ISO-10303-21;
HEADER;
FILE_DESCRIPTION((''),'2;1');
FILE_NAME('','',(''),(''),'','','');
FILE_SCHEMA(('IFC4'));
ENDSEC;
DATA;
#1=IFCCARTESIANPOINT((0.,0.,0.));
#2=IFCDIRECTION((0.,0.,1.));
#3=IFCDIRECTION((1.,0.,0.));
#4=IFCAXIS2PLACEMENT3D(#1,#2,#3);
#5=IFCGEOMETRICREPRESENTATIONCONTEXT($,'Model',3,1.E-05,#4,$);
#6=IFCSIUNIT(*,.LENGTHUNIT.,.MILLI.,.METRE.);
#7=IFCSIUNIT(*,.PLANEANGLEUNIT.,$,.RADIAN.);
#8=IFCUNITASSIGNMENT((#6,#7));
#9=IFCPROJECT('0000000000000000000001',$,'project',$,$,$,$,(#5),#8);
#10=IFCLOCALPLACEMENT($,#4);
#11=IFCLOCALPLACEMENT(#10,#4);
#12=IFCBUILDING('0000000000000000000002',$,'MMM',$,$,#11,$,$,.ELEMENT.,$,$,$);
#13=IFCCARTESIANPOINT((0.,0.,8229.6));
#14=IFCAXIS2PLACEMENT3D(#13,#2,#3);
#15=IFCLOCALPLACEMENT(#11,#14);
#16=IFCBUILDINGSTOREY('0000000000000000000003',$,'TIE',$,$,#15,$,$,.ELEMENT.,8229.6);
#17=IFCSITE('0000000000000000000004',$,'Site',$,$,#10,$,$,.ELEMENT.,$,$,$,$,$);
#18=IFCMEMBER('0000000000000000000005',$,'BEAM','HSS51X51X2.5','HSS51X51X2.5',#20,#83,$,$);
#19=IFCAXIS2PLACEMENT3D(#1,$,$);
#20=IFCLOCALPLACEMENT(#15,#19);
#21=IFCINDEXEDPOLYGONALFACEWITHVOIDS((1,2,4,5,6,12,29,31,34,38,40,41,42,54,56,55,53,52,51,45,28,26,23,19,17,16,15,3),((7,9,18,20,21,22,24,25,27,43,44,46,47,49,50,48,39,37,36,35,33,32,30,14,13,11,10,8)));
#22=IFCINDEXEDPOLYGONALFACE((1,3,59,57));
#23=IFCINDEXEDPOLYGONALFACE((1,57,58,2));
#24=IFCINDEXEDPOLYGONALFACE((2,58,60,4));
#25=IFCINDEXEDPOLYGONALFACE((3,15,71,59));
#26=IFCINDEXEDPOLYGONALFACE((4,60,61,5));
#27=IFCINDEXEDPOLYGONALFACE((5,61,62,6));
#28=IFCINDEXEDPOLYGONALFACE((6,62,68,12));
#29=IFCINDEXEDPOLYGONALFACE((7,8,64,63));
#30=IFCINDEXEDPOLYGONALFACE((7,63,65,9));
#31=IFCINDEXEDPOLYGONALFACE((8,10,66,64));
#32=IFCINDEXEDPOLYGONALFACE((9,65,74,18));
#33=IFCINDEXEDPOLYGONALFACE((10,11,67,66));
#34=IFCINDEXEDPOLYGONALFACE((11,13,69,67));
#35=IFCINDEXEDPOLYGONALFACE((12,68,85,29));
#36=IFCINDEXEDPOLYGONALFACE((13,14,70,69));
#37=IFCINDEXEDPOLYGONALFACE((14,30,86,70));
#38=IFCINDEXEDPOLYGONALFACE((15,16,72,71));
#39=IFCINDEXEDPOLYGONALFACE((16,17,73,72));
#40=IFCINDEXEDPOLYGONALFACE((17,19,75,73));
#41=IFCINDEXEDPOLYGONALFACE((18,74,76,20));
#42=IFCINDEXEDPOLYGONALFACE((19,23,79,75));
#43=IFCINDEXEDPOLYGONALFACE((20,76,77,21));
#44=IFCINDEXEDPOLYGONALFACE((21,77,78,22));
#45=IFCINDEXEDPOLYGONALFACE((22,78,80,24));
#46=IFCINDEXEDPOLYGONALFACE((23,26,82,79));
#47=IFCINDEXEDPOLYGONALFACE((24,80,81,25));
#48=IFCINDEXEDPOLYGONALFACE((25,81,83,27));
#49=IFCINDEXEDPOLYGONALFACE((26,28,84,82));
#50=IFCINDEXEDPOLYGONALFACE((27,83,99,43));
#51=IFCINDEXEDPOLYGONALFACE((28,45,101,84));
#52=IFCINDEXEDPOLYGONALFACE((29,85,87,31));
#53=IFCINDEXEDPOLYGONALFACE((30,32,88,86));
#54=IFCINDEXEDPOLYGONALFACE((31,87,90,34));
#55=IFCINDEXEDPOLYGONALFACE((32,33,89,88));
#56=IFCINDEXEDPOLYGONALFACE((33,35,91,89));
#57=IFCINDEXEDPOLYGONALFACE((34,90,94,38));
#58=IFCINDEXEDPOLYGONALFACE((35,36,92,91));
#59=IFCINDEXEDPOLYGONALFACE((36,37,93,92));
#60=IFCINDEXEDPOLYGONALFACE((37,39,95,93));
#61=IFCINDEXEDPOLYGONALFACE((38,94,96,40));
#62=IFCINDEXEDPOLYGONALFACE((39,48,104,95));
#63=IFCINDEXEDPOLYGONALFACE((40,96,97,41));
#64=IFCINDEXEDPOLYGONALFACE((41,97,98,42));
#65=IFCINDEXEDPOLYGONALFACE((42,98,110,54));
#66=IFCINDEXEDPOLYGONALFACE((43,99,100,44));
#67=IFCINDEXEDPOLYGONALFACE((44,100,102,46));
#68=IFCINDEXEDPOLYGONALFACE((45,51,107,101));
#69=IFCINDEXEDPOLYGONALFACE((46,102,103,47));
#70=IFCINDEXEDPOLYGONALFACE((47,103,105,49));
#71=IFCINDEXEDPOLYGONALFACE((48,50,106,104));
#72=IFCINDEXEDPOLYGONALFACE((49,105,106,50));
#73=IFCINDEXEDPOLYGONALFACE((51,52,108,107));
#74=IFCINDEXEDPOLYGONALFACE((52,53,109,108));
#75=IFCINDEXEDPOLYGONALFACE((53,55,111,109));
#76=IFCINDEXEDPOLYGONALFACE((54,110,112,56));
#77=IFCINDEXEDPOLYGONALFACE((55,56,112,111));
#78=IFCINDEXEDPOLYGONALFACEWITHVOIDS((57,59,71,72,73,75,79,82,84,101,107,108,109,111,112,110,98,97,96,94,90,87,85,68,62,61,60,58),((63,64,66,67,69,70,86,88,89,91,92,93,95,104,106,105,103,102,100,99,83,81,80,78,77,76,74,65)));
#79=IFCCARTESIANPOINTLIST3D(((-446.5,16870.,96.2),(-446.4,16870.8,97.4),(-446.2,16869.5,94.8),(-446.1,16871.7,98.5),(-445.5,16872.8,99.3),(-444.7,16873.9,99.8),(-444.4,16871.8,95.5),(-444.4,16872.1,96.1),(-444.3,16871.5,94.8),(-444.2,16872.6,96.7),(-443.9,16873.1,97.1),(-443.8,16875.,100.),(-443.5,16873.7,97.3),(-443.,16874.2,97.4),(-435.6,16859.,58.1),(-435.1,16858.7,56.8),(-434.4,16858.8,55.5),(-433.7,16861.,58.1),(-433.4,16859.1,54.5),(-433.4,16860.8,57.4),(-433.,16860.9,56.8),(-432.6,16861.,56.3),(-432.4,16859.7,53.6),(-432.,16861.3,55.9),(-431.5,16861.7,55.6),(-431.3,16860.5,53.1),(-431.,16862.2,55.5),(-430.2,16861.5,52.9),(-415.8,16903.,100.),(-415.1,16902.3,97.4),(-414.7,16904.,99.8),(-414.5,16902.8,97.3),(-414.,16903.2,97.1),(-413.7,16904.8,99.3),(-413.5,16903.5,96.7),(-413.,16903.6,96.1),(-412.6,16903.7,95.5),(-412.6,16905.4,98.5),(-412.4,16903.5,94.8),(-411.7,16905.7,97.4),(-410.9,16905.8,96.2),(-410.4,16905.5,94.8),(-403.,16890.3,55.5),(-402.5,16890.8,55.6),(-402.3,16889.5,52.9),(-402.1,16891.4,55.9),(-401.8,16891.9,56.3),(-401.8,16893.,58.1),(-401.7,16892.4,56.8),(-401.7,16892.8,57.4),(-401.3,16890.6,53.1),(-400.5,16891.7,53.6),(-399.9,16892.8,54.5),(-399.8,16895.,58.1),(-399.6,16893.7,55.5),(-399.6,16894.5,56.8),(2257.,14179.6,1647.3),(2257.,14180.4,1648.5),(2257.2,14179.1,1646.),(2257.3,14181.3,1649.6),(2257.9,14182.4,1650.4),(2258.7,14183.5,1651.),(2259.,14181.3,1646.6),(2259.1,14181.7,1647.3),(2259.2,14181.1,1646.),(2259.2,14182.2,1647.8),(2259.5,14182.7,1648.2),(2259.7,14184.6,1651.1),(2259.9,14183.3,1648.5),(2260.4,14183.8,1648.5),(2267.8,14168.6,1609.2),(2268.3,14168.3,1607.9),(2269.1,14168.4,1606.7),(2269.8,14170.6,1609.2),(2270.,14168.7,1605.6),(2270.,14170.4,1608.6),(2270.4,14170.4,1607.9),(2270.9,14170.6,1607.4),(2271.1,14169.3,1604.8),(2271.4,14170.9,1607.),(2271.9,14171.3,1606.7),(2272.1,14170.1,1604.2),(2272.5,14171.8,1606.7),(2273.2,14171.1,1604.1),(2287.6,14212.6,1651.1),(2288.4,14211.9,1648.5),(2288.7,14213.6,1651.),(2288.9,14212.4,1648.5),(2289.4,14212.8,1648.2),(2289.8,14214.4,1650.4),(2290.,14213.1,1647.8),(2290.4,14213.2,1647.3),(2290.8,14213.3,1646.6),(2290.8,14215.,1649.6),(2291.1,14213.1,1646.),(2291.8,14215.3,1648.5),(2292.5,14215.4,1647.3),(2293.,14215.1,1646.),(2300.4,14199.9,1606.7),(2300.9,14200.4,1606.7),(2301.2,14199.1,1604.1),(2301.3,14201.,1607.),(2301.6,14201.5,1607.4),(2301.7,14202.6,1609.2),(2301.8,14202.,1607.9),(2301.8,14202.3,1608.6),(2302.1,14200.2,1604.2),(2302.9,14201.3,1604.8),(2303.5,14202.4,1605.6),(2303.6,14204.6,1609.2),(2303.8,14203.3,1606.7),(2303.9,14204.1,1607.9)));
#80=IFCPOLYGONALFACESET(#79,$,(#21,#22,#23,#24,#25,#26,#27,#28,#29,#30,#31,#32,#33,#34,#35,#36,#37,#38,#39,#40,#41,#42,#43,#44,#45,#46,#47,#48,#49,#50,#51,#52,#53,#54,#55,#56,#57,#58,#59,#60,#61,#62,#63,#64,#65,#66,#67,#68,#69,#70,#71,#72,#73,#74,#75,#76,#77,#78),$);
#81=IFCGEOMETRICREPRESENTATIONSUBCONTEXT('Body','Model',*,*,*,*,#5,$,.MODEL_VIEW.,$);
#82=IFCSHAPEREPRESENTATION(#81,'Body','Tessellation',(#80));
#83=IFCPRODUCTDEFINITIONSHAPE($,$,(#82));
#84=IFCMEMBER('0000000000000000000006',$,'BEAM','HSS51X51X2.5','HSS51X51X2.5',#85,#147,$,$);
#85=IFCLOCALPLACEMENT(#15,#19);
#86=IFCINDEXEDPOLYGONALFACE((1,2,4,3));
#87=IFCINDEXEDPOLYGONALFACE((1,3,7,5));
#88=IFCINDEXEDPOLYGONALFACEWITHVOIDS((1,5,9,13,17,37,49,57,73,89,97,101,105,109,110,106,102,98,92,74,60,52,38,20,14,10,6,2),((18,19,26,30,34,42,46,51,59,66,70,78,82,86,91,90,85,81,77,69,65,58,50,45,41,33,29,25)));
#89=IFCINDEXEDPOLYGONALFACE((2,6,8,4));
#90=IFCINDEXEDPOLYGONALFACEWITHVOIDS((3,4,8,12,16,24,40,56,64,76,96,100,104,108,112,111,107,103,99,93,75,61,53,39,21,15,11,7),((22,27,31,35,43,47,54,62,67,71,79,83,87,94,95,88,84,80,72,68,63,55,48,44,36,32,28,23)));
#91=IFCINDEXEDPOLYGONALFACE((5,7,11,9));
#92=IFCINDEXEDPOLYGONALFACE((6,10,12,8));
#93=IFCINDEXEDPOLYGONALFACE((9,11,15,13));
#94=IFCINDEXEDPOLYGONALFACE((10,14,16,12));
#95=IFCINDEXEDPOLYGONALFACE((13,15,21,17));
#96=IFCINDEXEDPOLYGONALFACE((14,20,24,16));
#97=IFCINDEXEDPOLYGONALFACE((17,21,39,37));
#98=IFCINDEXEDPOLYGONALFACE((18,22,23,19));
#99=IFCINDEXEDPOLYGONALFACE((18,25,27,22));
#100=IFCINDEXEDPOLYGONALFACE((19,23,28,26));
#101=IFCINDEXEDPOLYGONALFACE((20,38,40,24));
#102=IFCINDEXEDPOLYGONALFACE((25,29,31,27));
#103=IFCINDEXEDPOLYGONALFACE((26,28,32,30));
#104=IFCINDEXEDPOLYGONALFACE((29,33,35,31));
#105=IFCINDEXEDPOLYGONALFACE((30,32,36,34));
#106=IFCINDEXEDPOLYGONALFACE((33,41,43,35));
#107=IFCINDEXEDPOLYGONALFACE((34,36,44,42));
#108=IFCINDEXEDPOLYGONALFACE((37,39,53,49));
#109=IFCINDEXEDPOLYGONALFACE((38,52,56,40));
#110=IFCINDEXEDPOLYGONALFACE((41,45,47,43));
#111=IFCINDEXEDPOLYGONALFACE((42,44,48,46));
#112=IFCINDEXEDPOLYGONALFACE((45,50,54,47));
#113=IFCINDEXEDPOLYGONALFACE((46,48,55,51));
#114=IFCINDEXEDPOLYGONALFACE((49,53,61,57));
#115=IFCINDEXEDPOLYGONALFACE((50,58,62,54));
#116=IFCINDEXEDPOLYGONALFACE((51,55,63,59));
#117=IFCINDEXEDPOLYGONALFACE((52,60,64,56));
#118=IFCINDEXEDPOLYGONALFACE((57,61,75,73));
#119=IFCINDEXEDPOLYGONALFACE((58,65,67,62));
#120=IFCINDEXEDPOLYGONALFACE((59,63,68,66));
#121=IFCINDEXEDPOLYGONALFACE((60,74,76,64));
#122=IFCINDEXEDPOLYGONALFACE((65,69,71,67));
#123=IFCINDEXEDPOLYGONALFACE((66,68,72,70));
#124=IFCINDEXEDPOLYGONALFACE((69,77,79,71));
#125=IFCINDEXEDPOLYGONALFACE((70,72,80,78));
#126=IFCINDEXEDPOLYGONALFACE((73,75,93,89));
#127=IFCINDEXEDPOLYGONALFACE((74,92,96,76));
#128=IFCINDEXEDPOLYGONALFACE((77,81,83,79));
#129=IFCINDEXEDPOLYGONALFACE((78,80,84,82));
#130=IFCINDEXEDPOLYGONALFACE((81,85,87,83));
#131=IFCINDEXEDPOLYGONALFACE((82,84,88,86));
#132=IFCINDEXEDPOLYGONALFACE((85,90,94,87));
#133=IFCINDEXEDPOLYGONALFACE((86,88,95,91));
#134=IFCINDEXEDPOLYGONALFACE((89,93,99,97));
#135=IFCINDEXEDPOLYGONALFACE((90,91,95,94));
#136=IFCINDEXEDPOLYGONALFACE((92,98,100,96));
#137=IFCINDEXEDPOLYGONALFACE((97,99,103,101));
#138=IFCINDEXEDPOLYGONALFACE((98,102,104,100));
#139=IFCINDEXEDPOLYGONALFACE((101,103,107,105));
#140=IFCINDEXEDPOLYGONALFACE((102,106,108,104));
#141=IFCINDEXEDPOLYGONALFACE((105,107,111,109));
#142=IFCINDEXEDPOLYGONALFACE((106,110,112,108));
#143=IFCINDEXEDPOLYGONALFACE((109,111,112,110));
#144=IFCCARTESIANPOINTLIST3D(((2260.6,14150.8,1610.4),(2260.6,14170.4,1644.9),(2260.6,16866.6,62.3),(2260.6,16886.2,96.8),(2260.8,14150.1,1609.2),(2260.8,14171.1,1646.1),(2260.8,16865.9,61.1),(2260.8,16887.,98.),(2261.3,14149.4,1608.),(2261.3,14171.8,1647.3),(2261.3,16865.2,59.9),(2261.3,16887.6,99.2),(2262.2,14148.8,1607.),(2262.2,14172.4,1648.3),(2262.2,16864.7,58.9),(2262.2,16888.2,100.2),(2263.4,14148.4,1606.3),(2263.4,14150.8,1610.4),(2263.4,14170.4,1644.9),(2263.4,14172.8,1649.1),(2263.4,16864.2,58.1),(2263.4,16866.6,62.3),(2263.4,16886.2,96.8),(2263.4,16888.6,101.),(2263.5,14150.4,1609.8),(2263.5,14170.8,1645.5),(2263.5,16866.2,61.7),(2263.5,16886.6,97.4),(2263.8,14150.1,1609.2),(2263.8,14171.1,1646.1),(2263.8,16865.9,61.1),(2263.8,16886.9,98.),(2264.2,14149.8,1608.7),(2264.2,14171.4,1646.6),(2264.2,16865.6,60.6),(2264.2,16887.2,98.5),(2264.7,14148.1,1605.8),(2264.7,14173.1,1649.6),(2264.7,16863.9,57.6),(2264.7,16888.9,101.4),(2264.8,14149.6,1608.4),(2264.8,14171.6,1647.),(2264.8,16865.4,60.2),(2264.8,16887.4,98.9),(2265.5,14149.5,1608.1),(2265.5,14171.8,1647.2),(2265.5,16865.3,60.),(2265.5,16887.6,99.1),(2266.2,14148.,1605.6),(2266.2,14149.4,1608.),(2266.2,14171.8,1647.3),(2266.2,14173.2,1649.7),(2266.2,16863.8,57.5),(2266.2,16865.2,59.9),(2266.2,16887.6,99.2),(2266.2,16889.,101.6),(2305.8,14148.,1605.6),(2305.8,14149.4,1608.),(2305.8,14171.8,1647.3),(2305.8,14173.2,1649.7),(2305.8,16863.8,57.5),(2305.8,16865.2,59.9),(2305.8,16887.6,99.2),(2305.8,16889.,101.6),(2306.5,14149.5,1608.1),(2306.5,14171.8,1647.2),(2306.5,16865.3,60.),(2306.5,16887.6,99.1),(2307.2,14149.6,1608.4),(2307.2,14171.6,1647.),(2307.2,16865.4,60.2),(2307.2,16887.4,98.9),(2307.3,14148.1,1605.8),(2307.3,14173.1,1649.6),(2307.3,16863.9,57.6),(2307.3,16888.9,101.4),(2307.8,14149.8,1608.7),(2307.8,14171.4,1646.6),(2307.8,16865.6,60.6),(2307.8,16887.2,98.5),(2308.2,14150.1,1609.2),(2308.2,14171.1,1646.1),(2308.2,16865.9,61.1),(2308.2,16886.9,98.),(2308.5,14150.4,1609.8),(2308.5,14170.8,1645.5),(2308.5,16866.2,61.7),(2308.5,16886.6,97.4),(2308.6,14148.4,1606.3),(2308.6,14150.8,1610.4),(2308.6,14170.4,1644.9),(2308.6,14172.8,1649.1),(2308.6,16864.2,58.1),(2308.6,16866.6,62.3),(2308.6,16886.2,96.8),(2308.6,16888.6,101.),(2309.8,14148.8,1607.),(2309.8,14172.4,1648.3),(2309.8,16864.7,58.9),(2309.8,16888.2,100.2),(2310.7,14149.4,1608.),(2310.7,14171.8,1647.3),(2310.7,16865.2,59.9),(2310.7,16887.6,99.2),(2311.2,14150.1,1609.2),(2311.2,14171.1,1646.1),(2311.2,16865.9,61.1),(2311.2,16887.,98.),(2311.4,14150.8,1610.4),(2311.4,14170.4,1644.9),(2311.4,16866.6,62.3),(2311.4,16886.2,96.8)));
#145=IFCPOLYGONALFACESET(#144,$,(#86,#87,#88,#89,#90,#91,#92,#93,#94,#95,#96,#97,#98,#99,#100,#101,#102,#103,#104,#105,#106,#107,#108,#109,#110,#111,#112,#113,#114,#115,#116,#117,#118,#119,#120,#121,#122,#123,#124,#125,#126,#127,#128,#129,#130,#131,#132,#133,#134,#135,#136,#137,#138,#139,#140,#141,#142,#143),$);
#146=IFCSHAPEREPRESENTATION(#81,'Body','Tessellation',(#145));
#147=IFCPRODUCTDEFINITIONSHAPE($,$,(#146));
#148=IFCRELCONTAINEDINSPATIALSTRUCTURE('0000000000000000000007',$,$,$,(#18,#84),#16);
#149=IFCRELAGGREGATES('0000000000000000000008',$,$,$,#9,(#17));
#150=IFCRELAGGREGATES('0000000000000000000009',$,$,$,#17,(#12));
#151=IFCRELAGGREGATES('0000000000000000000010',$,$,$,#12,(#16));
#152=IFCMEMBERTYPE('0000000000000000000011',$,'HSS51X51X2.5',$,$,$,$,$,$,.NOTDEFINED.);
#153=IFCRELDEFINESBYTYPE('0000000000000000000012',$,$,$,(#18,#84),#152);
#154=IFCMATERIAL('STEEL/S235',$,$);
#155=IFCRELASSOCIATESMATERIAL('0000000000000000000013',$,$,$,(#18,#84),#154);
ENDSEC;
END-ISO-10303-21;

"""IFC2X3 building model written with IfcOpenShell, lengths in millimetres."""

from ifc_helpers import new_model, si_unit, frame, origin_with_axes, origin_2d_with_axis, place, context, subcontext, project, spatial, hollow_rectangle, extrude, material, type_object, element, save


model = new_model("IFC2X3")

# Units and contexts
model_context = context("Model", 3, precision=1e-05, world=origin_with_axes())
body_context = subcontext(model_context, "Body", "Model", "MODEL_VIEW")
ifc_project = project(units=[si_unit("LENGTHUNIT", "METRE", prefix="MILLI"), si_unit("PLANEANGLEUNIT", "RADIAN")], contexts=[model_context])

# Site, building, storey
site_placement = place(None, origin_with_axes())
site = spatial("IfcSite", under=ifc_project, at=site_placement, Name="Site", CompositionType="ELEMENT")
building_placement = place(site_placement, origin_with_axes())
building = spatial("IfcBuilding", under=site, at=building_placement, Name="MMM", CompositionType="ELEMENT")
storey_placement = place(building_placement, frame((0.0, 0.0, 8229.6), z_axis=(0.0, 0.0, 1.0), x_axis=(1.0, 0.0, 0.0)))
storey = spatial("IfcBuildingStorey", under=building, at=storey_placement, Name="TIE", CompositionType="ELEMENT", Elevation=8229.6)

# Shared definitions
ifc_material = material(Name="STEEL/S235")

# Members
member_type_1 = type_object("IfcMemberType", Name="HSS51X51X2.5", PredefinedType="NOTDEFINED")
member_1_placement = place(storey_placement, frame((2280.4, 14191.9, 1627.6), z_axis=(-0.267029, 0.265742, 0.926324), x_axis=(-0.656591, 0.653426, -0.376727)))
element("IfcMember", 1, at=member_1_placement, inside=storey, type_object=member_type_1, material=ifc_material, Name="BEAM", Description="HSS51X51X2.5", ObjectType="HSS51X51X2.5", context=body_context, shape_type="SweptSolid", body=[
    extrude(hollow_rectangle(XDim=50.8, YDim=50.8, WallThickness=2.8, InnerFilletRadius=2.8, OuterFilletRadius=5.6, at=origin_2d_with_axis()), frame((4117.4, 0.0, 0.0), z_axis=(-1.0, 0.0, 0.0), x_axis=(0.0, -1.0, 0.0)), (0.0, 0.0, 1.0), 4117.4),
])
member_2_placement = place(storey_placement, frame((2286.0, 14160.6, 1627.7), z_axis=(0.0, 0.495234, 0.86876), x_axis=(0.0, 0.86876, -0.495234)))
element("IfcMember", 2, at=member_2_placement, inside=storey, type_object=member_type_1, material=ifc_material, Name="BEAM", Description="HSS51X51X2.5", ObjectType="HSS51X51X2.5", context=body_context, shape_type="SweptSolid", body=[
    extrude(hollow_rectangle(XDim=50.8, YDim=50.8, WallThickness=2.8, InnerFilletRadius=2.8, OuterFilletRadius=5.6, at=origin_2d_with_axis()), frame((3126.1, 0.0, 0.0), z_axis=(-1.0, 0.0, 0.0), x_axis=(0.0, -1.0, 0.0)), (0.0, 0.0, 1.0), 3126.1),
])

save(model, "model.ifc")
